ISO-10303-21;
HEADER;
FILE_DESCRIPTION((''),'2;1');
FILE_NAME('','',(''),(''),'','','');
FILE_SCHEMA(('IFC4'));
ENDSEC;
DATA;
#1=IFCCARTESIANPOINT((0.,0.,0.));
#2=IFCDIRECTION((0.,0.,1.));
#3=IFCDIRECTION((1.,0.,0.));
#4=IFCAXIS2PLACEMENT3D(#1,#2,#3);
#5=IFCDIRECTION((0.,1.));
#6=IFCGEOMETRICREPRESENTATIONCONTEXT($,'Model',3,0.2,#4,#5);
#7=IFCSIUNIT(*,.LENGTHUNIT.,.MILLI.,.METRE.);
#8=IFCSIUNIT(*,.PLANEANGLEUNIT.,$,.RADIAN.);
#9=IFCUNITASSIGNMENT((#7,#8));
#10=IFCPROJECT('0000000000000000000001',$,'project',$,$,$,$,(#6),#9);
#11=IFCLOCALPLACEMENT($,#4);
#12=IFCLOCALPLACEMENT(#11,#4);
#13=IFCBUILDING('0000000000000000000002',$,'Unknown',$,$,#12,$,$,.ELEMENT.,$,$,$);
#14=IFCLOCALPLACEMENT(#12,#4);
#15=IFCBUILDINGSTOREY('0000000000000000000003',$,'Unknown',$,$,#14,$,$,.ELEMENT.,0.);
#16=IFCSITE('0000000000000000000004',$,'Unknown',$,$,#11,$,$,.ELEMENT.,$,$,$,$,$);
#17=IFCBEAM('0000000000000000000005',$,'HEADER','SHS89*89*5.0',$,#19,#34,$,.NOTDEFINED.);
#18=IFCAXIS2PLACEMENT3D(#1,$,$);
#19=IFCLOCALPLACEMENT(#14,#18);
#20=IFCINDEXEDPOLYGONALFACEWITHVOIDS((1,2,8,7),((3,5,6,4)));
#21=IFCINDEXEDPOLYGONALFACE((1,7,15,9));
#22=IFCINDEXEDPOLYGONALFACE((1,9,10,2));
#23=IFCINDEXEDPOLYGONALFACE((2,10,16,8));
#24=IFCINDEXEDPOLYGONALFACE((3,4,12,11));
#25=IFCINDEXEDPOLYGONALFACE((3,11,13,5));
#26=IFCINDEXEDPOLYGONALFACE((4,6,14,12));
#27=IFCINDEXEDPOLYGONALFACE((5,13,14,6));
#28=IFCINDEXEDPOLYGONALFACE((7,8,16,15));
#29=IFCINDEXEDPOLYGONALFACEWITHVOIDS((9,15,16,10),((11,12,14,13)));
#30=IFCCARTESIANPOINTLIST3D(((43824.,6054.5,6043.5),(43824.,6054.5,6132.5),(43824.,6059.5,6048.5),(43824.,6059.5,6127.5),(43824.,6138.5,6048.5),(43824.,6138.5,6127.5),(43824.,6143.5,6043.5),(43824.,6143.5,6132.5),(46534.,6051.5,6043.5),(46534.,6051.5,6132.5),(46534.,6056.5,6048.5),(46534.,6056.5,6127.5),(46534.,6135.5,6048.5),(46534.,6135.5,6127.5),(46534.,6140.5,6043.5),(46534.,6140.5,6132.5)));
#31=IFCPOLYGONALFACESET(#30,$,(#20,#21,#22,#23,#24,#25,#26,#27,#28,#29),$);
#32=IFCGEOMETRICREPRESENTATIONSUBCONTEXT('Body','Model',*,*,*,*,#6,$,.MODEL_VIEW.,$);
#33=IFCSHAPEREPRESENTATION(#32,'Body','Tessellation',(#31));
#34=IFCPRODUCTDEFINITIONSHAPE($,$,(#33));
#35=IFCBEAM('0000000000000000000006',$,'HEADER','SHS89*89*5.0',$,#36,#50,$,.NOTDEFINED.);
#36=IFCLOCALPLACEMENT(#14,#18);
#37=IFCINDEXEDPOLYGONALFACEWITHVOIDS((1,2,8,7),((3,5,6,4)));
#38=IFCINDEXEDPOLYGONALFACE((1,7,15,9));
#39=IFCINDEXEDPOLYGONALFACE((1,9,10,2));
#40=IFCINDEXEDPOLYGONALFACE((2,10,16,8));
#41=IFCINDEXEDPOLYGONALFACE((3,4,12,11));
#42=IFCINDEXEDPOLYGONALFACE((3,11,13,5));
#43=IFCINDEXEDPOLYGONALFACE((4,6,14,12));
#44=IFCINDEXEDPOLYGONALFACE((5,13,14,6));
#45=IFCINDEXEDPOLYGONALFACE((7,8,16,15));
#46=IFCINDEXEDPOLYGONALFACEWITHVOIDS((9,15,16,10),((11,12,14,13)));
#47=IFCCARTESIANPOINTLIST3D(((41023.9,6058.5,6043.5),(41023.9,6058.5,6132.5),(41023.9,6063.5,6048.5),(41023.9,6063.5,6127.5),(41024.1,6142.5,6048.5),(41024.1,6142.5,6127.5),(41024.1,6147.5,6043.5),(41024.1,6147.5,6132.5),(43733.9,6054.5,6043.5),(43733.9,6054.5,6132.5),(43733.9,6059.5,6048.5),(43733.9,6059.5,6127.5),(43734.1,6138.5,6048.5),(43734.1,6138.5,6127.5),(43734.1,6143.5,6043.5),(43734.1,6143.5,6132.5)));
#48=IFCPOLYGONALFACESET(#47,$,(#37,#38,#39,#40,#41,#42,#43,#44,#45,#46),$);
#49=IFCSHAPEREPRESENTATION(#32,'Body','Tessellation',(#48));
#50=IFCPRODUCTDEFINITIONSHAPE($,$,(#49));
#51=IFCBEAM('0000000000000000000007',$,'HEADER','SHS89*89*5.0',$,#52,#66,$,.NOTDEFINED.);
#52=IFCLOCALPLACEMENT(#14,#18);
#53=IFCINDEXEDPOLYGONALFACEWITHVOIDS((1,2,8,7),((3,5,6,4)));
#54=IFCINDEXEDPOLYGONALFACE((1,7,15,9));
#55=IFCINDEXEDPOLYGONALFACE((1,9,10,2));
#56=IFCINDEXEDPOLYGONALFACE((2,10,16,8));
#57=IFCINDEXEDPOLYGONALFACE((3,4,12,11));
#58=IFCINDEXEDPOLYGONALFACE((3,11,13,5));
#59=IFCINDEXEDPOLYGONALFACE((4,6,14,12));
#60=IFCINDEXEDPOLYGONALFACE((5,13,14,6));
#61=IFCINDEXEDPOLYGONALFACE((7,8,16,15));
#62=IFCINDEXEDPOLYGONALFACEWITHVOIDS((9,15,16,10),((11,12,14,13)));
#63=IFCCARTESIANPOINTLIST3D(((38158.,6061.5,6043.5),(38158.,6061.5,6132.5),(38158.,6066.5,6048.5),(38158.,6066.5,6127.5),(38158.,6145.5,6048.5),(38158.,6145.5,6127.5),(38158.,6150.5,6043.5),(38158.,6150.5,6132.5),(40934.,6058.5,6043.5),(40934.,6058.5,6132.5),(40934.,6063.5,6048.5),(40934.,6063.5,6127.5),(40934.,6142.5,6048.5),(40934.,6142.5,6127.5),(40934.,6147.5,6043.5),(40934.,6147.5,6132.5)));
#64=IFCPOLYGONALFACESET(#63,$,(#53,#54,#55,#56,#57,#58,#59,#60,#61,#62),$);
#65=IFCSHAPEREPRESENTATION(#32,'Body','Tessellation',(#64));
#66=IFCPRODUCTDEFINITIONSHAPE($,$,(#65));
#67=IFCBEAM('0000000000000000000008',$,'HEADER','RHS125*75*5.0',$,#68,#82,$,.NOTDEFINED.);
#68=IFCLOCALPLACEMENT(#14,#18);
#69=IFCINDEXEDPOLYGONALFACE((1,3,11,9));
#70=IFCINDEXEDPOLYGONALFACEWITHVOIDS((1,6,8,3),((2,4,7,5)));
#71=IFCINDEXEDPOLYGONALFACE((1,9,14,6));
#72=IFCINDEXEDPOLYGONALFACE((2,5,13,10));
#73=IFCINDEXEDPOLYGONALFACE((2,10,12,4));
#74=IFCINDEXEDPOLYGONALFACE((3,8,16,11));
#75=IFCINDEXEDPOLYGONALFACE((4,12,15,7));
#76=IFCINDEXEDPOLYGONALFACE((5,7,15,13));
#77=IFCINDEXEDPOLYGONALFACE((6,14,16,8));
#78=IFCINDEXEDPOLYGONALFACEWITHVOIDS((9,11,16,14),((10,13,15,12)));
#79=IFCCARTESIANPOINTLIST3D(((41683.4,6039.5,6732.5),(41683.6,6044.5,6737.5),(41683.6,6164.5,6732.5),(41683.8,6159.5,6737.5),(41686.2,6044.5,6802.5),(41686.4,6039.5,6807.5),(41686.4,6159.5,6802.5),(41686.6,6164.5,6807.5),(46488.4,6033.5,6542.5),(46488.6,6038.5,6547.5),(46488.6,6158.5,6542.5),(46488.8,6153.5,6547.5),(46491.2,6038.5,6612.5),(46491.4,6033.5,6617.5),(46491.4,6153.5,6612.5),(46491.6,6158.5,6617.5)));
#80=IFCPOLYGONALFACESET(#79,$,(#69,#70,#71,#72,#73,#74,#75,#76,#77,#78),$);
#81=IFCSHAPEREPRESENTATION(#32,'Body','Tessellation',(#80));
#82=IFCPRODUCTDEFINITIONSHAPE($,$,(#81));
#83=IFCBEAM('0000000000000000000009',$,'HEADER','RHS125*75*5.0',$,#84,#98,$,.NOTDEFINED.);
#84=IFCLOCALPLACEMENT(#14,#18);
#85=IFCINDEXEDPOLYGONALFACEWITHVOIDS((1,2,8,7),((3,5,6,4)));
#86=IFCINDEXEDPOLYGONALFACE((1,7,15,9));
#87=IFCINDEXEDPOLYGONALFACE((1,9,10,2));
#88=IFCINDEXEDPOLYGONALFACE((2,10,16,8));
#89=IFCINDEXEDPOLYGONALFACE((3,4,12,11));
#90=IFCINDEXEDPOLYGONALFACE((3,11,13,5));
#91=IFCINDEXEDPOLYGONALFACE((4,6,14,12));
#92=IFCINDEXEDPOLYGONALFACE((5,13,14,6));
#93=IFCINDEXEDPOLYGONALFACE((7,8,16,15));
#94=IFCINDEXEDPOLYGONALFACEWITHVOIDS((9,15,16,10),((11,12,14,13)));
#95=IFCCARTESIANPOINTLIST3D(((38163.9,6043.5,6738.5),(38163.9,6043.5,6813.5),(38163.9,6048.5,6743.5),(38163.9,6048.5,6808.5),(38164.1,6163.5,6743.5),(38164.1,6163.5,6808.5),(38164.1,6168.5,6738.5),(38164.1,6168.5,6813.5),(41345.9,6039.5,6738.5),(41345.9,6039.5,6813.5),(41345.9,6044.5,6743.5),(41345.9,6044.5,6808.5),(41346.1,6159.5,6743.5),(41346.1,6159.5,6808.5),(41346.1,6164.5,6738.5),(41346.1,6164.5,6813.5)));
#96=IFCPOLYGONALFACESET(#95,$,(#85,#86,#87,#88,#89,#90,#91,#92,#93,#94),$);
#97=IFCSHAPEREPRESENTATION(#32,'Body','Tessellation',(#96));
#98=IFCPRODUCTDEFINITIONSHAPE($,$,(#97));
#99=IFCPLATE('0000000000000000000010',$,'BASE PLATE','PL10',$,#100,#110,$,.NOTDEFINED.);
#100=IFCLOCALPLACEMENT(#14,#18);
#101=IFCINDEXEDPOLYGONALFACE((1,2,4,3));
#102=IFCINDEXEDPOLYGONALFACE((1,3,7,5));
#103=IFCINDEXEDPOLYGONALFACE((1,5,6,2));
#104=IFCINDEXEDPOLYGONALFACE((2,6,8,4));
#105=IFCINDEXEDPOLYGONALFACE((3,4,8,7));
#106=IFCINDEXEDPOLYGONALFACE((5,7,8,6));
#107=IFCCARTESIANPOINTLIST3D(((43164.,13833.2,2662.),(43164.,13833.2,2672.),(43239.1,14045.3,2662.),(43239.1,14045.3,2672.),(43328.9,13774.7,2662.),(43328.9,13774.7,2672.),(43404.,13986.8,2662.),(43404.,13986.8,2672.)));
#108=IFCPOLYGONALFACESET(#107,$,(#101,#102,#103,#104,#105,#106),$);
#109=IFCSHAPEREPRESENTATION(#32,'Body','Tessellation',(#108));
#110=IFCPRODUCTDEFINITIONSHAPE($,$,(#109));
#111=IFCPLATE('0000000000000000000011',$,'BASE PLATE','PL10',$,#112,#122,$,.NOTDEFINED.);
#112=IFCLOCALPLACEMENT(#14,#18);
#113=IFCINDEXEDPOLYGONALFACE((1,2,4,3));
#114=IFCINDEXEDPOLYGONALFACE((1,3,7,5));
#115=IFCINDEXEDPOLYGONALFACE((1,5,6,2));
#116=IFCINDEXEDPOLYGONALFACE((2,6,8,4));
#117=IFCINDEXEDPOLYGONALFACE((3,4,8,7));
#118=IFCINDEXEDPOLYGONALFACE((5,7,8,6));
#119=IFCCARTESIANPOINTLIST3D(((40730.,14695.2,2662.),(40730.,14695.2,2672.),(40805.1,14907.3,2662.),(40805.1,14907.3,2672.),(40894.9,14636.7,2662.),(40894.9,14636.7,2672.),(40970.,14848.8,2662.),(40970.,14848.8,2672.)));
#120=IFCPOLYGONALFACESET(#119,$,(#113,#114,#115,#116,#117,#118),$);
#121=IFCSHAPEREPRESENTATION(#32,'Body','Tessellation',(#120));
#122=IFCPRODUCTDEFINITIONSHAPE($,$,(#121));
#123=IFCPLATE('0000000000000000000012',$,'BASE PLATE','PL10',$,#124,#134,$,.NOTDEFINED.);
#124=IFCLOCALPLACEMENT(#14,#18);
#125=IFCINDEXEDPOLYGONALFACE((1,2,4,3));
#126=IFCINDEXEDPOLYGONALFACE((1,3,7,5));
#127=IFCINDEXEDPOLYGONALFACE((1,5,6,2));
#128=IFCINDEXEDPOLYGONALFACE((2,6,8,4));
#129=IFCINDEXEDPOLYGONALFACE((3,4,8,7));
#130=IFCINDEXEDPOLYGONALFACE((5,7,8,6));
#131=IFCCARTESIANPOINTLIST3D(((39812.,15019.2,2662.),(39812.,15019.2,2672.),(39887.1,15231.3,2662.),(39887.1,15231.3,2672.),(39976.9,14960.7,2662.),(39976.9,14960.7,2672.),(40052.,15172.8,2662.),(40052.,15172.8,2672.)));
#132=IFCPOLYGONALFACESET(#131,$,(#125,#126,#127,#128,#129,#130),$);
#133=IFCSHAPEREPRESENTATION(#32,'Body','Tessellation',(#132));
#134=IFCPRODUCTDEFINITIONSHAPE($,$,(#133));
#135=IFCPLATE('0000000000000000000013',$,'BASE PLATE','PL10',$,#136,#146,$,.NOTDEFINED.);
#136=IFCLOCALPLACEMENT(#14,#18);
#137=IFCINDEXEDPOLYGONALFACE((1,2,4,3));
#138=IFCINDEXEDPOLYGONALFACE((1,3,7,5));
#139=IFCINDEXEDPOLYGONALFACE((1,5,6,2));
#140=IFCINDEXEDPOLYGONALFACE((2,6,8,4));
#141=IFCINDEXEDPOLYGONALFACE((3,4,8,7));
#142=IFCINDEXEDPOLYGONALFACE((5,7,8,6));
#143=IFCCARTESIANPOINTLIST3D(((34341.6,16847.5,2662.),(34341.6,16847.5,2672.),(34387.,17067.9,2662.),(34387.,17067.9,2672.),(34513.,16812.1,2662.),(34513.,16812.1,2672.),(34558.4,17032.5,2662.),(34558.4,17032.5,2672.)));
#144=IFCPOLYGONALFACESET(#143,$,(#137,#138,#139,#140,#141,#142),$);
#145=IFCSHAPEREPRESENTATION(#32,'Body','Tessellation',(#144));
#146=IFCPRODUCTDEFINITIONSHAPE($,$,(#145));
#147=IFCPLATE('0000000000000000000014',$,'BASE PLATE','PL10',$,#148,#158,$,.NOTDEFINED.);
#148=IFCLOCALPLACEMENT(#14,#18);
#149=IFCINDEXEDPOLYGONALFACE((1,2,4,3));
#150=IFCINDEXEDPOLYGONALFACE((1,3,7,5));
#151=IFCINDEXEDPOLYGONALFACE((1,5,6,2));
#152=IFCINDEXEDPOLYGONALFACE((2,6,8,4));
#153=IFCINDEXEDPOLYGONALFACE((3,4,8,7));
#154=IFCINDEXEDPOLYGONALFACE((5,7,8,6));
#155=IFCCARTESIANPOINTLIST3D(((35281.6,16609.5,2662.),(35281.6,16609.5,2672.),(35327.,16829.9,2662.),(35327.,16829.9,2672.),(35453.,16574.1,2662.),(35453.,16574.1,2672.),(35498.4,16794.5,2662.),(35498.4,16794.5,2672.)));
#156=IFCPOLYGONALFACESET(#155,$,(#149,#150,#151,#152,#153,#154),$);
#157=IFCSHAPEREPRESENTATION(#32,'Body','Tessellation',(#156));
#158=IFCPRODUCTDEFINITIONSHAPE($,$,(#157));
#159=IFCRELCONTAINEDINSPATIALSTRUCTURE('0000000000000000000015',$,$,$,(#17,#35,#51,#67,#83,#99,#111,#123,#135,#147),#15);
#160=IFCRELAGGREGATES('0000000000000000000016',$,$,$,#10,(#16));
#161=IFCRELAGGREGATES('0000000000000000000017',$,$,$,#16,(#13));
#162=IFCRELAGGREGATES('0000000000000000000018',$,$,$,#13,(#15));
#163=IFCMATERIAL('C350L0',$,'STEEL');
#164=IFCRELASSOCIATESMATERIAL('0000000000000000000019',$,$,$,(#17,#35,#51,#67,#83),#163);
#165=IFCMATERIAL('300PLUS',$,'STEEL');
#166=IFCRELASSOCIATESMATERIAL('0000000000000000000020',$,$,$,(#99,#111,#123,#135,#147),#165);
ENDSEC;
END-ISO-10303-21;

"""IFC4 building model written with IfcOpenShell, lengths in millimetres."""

from ifc_helpers import new_model, si_unit, direction, frame, origin_with_axes, place, context, subcontext, project, spatial, line, indexed_curve, outline, extrude, material, element, save


model = new_model("IFC4")

# Units and contexts
model_context = context("Model", 3, precision=0.2, world=origin_with_axes(), true_north=direction((0.0, 1.0)))
body_context = subcontext(model_context, "Body", "Model", "MODEL_VIEW")
ifc_project = project(units=[si_unit("LENGTHUNIT", "METRE", prefix="MILLI"), si_unit("PLANEANGLEUNIT", "RADIAN")], contexts=[model_context])

# Site, building, storey
site_placement = place(None, origin_with_axes())
site = spatial("IfcSite", under=ifc_project, at=site_placement, Name="Unknown", CompositionType="ELEMENT")
building_placement = place(site_placement, origin_with_axes())
building = spatial("IfcBuilding", under=site, at=building_placement, Name="Unknown", CompositionType="ELEMENT")
storey_placement = place(building_placement, origin_with_axes())
storey = spatial("IfcBuildingStorey", under=building, at=storey_placement, Name="Unknown", CompositionType="ELEMENT", Elevation=0.0)

# Shared definitions
ifc_material_1 = material(Name="C350L0", Category="STEEL")

# Beams
beam_1_placement = place(storey_placement, frame((43824.0, 6099.0, 6088.0), z_axis=(0.0, 0.0, 1.0), x_axis=(0.999999, -0.001107, 0.0)))
element("IfcBeam", 1, at=beam_1_placement, inside=storey, material=ifc_material_1, Name="HEADER", Description="SHS89*89*5.0", PredefinedType="NOTDEFINED", context=body_context, shape_type="SolidModel", body=[
    extrude(outline(indexed_curve([(-44.5, -44.5), (44.5, -44.5), (44.5, 44.5), (-44.5, 44.5)], segments=[line(1, 2, 3, 4, 1)]), holes=[indexed_curve([(-39.5, -39.5), (-39.5, 39.5), (39.5, 39.5), (39.5, -39.5)], segments=[line(1, 2, 3, 4, 1)])]), frame((0.0, 0.0, 0.0), z_axis=(-1.0, 0.0, 0.0), x_axis=(0.0, 0.0, 1.0)), (0.0, 0.0, -1.0), 2710.0),
])
beam_2_placement = place(storey_placement, frame((41024.0, 6103.0, 6088.0), z_axis=(0.0, 0.0, 1.0), x_axis=(0.999999, -0.001476, 0.0)))
element("IfcBeam", 2, at=beam_2_placement, inside=storey, material=ifc_material_1, Name="HEADER", Description="SHS89*89*5.0", PredefinedType="NOTDEFINED", context=body_context, shape_type="SolidModel", body=[
    extrude(outline(indexed_curve([(-44.5, -44.5), (44.5, -44.5), (44.5, 44.5), (-44.5, 44.5)], segments=[line(1, 2, 3, 4, 1)]), holes=[indexed_curve([(-39.5, -39.5), (-39.5, 39.5), (39.5, 39.5), (39.5, -39.5)], segments=[line(1, 2, 3, 4, 1)])]), frame((0.0, 0.0, 0.0), z_axis=(-1.0, 0.0, 0.0), x_axis=(0.0, 0.0, 1.0)), (0.0, 0.0, -1.0), 2710.0),
])
beam_3_placement = place(storey_placement, frame((38158.0, 6106.0, 6088.0), z_axis=(0.0, 0.0, 1.0), x_axis=(0.999999, -0.001081, 0.0)))
element("IfcBeam", 3, at=beam_3_placement, inside=storey, material=ifc_material_1, Name="HEADER", Description="SHS89*89*5.0", PredefinedType="NOTDEFINED", context=body_context, shape_type="SolidModel", body=[
    extrude(outline(indexed_curve([(-44.5, -44.5), (44.5, -44.5), (44.5, 44.5), (-44.5, 44.5)], segments=[line(1, 2, 3, 4, 1)]), holes=[indexed_curve([(-39.5, -39.5), (-39.5, 39.5), (39.5, 39.5), (39.5, -39.5)], segments=[line(1, 2, 3, 4, 1)])]), frame((0.0, 0.0, 0.0), z_axis=(-1.0, 0.0, 0.0), x_axis=(0.0, 0.0, 1.0)), (0.0, 0.0, -1.0), 2776.0),
])
beam_4_placement = place(storey_placement, frame((41685.0, 6102.0, 6770.0), z_axis=(0.039511, -0.000049, 0.999219), x_axis=(0.999218, -0.001248, -0.039511)))
element("IfcBeam", 4, at=beam_4_placement, inside=storey, material=ifc_material_1, Name="HEADER", Description="RHS125*75*5.0", PredefinedType="NOTDEFINED", context=body_context, shape_type="SolidModel", body=[
    extrude(outline(indexed_curve([(-37.5, -62.5), (37.5, -62.5), (37.5, 62.5), (-37.5, 62.5)], segments=[line(1, 2, 3, 4, 1)]), holes=[indexed_curve([(-32.5, -57.5), (-32.5, 57.5), (32.5, 57.5), (32.5, -57.5)], segments=[line(1, 2, 3, 4, 1)])]), frame((0.0, 0.0, 0.0), z_axis=(-1.0, 0.0, 0.0), x_axis=(0.0, 0.0, 1.0)), (0.0, 0.0, -1.0), 4808.8),
])
beam_5_placement = place(storey_placement, frame((38164.0, 6106.0, 6776.0), z_axis=(0.0, 0.0, 1.0), x_axis=(0.999999, -0.001257, 0.0)))
element("IfcBeam", 5, at=beam_5_placement, inside=storey, material=ifc_material_1, Name="HEADER", Description="RHS125*75*5.0", PredefinedType="NOTDEFINED", context=body_context, shape_type="SolidModel", body=[
    extrude(outline(indexed_curve([(-37.5, -62.5), (37.5, -62.5), (37.5, 62.5), (-37.5, 62.5)], segments=[line(1, 2, 3, 4, 1)]), holes=[indexed_curve([(-32.5, -57.5), (-32.5, 57.5), (32.5, 57.5), (32.5, -57.5)], segments=[line(1, 2, 3, 4, 1)])]), frame((0.0, 0.0, 0.0), z_axis=(-1.0, 0.0, 0.0), x_axis=(0.0, 0.0, 1.0)), (0.0, 0.0, -1.0), 3182.0),
])

# Plates
ifc_material_2 = material(Name="300PLUS", Category="STEEL")
for number, where, z_axis, x_axis, name in (
    (6, (43328.9, 13774.7, 2667.0), (0.0, 0.0, 1.0), (0.333773, 0.942653, 0.0), "BASE PLATE"),
    (7, (40894.9, 14636.7, 2667.0), (0.0, 0.0, 1.0), (0.333773, 0.942653, 0.0), "BASE PLATE"),
    (8, (39976.9, 14960.7, 2667.0), (0.0, 0.0, 1.0), (0.333773, 0.942653, 0.0), "BASE PLATE"),
):
    element("IfcPlate", number, at=place(storey_placement, frame(where, z_axis=z_axis, x_axis=x_axis)), inside=storey, material=ifc_material_2, Name=name, Description="PL10", PredefinedType="NOTDEFINED", context=body_context, shape_type="SolidModel", body=[
        extrude(outline(indexed_curve([(0.0, 0.0), (225.0, 0.0), (225.1, 175.0), (0.1, 175.0)], segments=[line(1, 2, 3, 4, 1)])), frame((0.0, 0.0, 5.0), z_axis=(0.0, 0.0, 1.0), x_axis=(1.0, 0.0, 0.0)), (0.0, 0.0, -1.0), 10.0),
    ])
for number, where, z_axis, x_axis, name in (
    (9, (34513.0, 16812.1, 2667.0), (0.0, 0.0, 1.0), (0.201753, 0.979436, 0.0), "BASE PLATE"),
    (10, (35453.0, 16574.1, 2667.0), (0.0, 0.0, 1.0), (0.201753, 0.979436, 0.0), "BASE PLATE"),
):
    element("IfcPlate", number, at=place(storey_placement, frame(where, z_axis=z_axis, x_axis=x_axis)), inside=storey, material=ifc_material_2, Name=name, Description="PL10", PredefinedType="NOTDEFINED", context=body_context, shape_type="SolidModel", body=[
        extrude(outline(indexed_curve([(0.0, 0.0), (225.0, 0.0), (225.1, 175.0), (0.1, 175.0)], segments=[line(1, 2, 3, 4, 1)])), frame((0.0, 0.0, 5.0), z_axis=(0.0, 0.0, 1.0), x_axis=(1.0, 0.0, 0.0)), (0.0, 0.0, -1.0), 10.0),
    ])

save(model, "model.ifc")
